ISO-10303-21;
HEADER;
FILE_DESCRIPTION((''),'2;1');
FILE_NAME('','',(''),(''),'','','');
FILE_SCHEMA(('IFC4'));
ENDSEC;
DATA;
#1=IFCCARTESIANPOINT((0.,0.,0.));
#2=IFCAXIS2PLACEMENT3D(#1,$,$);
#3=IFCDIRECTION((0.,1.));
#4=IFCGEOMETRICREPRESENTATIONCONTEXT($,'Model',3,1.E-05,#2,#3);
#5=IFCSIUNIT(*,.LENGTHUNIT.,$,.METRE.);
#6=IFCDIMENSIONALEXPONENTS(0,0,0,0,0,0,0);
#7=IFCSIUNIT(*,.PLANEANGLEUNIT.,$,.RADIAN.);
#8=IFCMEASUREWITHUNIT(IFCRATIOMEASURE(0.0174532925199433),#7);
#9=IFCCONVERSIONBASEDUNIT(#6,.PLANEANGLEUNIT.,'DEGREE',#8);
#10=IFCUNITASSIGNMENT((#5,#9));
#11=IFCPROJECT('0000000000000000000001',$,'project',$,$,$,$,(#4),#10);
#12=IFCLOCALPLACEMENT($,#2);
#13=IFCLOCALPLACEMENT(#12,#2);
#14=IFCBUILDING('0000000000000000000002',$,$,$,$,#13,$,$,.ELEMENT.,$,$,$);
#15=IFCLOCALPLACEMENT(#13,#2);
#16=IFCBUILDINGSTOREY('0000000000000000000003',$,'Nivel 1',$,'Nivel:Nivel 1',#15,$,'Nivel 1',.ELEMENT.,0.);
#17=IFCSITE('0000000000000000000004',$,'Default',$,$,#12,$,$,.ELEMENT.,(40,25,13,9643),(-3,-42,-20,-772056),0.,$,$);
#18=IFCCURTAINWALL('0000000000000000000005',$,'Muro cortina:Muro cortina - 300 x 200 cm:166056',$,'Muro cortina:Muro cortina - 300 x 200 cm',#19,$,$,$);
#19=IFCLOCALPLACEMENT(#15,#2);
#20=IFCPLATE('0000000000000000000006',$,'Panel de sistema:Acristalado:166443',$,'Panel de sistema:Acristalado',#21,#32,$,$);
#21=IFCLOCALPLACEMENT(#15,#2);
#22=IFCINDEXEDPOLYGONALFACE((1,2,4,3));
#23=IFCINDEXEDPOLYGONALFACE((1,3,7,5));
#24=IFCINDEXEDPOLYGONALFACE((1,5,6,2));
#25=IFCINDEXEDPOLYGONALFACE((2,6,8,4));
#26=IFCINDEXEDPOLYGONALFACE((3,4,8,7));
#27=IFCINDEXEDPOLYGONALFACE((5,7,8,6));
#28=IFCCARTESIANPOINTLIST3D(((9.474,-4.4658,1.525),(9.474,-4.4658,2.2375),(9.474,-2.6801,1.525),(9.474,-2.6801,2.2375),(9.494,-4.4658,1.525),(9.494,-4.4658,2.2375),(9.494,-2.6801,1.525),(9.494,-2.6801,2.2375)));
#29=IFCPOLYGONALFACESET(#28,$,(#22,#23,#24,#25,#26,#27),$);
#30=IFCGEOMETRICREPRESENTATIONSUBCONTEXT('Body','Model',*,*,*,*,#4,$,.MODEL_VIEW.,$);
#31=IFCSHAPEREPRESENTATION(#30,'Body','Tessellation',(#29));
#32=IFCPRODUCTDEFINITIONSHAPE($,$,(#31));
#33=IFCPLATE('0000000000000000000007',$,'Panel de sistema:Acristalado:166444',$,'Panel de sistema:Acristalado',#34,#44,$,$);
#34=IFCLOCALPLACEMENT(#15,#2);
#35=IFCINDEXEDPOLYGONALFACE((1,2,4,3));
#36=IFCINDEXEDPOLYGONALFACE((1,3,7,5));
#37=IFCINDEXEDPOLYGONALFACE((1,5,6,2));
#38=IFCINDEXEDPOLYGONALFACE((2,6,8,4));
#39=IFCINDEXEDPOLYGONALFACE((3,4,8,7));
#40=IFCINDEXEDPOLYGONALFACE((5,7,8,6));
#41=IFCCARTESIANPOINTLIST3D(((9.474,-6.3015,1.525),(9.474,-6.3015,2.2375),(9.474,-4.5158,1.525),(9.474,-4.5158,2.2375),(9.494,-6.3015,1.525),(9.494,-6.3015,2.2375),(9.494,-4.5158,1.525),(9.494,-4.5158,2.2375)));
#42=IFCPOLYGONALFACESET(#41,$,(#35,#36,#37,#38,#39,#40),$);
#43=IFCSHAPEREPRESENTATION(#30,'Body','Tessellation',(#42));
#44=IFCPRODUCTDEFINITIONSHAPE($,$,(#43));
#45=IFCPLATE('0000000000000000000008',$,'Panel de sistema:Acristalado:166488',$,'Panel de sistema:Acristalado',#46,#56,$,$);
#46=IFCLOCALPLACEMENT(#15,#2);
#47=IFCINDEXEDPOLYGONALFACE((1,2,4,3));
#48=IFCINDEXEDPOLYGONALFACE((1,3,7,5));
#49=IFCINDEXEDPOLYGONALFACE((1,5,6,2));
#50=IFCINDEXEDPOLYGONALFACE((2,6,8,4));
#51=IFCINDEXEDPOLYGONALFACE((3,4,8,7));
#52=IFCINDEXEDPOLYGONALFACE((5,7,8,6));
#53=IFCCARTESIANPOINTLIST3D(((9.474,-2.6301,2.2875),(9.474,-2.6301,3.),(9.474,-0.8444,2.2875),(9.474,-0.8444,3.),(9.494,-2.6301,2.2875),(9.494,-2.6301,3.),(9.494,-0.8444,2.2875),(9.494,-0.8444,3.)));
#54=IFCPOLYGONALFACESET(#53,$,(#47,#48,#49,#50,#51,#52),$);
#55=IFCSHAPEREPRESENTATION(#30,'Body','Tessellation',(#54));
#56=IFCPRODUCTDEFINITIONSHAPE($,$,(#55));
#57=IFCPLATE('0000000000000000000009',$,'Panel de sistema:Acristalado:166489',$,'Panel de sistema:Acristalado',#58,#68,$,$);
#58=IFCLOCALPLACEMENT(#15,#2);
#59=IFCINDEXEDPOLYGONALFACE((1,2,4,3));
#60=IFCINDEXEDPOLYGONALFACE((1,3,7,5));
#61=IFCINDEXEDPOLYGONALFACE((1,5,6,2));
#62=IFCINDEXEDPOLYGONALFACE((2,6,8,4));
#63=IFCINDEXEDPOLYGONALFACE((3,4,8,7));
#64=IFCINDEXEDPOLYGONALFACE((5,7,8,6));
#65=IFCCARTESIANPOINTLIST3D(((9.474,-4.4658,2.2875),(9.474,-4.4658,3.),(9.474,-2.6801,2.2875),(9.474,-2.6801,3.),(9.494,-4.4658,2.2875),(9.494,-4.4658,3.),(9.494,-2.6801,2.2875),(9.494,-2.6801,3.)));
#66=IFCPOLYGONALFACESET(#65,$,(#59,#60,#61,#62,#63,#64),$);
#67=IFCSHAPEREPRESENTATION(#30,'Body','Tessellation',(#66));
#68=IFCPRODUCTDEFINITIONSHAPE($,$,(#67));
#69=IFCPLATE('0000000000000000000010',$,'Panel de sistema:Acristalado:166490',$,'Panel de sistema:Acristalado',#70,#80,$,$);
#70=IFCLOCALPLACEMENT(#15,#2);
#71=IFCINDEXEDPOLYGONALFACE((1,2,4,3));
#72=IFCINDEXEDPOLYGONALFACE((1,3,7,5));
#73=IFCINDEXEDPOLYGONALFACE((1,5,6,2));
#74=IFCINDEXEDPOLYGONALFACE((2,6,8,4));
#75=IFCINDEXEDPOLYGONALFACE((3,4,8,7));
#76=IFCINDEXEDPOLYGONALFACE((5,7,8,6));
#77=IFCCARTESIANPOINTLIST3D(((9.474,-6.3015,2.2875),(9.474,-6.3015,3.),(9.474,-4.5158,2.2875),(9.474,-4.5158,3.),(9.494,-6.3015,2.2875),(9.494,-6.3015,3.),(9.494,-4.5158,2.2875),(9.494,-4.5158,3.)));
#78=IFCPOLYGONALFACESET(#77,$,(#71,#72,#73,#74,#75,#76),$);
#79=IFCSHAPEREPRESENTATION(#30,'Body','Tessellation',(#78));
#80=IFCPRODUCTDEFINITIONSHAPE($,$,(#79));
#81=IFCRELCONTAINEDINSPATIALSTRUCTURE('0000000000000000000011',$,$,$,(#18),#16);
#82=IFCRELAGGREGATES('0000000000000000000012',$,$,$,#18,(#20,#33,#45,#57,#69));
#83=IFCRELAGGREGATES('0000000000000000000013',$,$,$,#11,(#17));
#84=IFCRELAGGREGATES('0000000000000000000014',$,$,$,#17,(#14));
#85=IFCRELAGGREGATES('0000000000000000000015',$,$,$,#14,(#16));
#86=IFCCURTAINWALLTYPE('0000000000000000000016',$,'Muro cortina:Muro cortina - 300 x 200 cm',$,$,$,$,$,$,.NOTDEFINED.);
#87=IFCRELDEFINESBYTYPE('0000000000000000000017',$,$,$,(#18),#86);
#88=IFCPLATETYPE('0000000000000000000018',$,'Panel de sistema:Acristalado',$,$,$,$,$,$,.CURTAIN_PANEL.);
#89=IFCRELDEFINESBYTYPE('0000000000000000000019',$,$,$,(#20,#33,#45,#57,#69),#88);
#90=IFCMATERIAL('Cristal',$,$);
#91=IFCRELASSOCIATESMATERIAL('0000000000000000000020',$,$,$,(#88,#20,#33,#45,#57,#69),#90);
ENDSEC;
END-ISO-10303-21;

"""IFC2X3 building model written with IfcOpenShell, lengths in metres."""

from ifc_helpers import new_model, entity, si_unit, converted_unit, direction, frame, origin, origin_2d_with_axis, place, context, subcontext, project, spatial, rectangle, extrude, source, transform, mapped, material, type_object, type_shapes, element, aggregate, save


model = new_model("IFC2X3")

# Units and contexts
model_context = context("Model", 3, precision=1e-05, world=origin(), true_north=direction((0.0, 1.0)))
body_context = subcontext(model_context, "Body", "Model", "MODEL_VIEW")
ifc_project = project(units=[si_unit("LENGTHUNIT", "METRE"), converted_unit("PLANEANGLEUNIT", "DEGREE", entity("IfcRatioMeasure", 0.0174532925199433), si_unit("PLANEANGLEUNIT", "RADIAN"), dimensions=[0, 0, 0, 0, 0, 0, 0])], contexts=[model_context])

# Site, building, storey
site_placement = place(None, origin())
site = spatial("IfcSite", under=ifc_project, at=site_placement, Name="Default", CompositionType="ELEMENT", RefLatitude=(40, 25, 13, 9643), RefLongitude=(-3, -42, -20, -772056), RefElevation=0.0)
building_placement = place(site_placement, origin())
building = spatial("IfcBuilding", under=site, at=building_placement, CompositionType="ELEMENT")
storey_placement = place(building_placement, origin())
storey = spatial("IfcBuildingStorey", under=building, at=storey_placement, Name="Nivel 1", ObjectType="Nivel:Nivel 1", LongName="Nivel 1", CompositionType="ELEMENT", Elevation=0.0)

# Curtain wall, plates
curtain_wall_type = type_object("IfcCurtainWallType", Name="Muro cortina:Muro cortina - 300 x 200 cm", PredefinedType="NOTDEFINED")
curtain_wall_placement = place(storey_placement, origin())
curtain_wall = element("IfcCurtainWall", 1, at=curtain_wall_placement, inside=storey, type_object=curtain_wall_type, Name="Muro cortina:Muro cortina - 300 x 200 cm:166056", ObjectType="Muro cortina:Muro cortina - 300 x 200 cm")
ifc_material_1 = material(Name="Cristal")
plate_type = type_object("IfcPlateType", Name="Panel de sistema:Acristalado", PredefinedType="CURTAIN_PANEL", material=ifc_material_1)
shared_shape_1 = source(origin(), body_context, "Body", "SweptSolid", [
    extrude(rectangle(XDim=0.02, YDim=1.7857, at=origin_2d_with_axis()), frame((0.0, 0.0, 0.0), z_axis=(0.0, 0.0, 1.0), x_axis=(0.0, 1.0, 0.0)), (0.0, 0.0, 1.0), 0.7125),
])
type_shapes(plate_type, [shared_shape_1])
plate_1_placement = place(curtain_wall_placement, frame((9.484, -3.573, 1.525), z_axis=(0.0, 0.0, 1.0), x_axis=(0.0, -1.0, 0.0)))
plate_1 = element("IfcPlate", 2, at=plate_1_placement, type_object=plate_type, material=ifc_material_1, Name="Panel de sistema:Acristalado:166443", ObjectType="Panel de sistema:Acristalado", context=body_context, shape_type="MappedRepresentation", body=[
    mapped(shared_shape_1, transform((0.0, 0.0, 0.0), scale=1.0)),
])
plate_2_placement = place(curtain_wall_placement, frame((9.484, -5.4087, 1.525), z_axis=(0.0, 0.0, 1.0), x_axis=(0.0, -1.0, 0.0)))
plate_2 = element("IfcPlate", 3, at=plate_2_placement, type_object=plate_type, material=ifc_material_1, Name="Panel de sistema:Acristalado:166444", ObjectType="Panel de sistema:Acristalado", context=body_context, shape_type="MappedRepresentation", body=[
    mapped(shared_shape_1, transform((0.0, 0.0, 0.0), scale=1.0)),
])
plate_3_placement = place(curtain_wall_placement, frame((9.484, -1.7373, 2.2875), z_axis=(0.0, 0.0, 1.0), x_axis=(0.0, -1.0, 0.0)))
plate_3 = element("IfcPlate", 4, at=plate_3_placement, type_object=plate_type, material=ifc_material_1, Name="Panel de sistema:Acristalado:166488", ObjectType="Panel de sistema:Acristalado", context=body_context, shape_type="MappedRepresentation", body=[
    mapped(shared_shape_1, transform((0.0, 0.0, 0.0), scale=1.0)),
])
plate_4_placement = place(curtain_wall_placement, frame((9.484, -3.573, 2.2875), z_axis=(0.0, 0.0, 1.0), x_axis=(0.0, -1.0, 0.0)))
plate_4 = element("IfcPlate", 5, at=plate_4_placement, type_object=plate_type, material=ifc_material_1, Name="Panel de sistema:Acristalado:166489", ObjectType="Panel de sistema:Acristalado", context=body_context, shape_type="MappedRepresentation", body=[
    mapped(shared_shape_1, transform((0.0, 0.0, 0.0), scale=1.0)),
])
plate_5_placement = place(curtain_wall_placement, frame((9.484, -5.4087, 2.2875), z_axis=(0.0, 0.0, 1.0), x_axis=(0.0, -1.0, 0.0)))
plate_5 = element("IfcPlate", 6, at=plate_5_placement, type_object=plate_type, material=ifc_material_1, Name="Panel de sistema:Acristalado:166490", ObjectType="Panel de sistema:Acristalado", context=body_context, shape_type="MappedRepresentation", body=[
    mapped(shared_shape_1, transform((0.0, 0.0, 0.0), scale=1.0)),
])
aggregate(curtain_wall, [plate_1, plate_2, plate_3, plate_4, plate_5])

save(model, "model.ifc")
